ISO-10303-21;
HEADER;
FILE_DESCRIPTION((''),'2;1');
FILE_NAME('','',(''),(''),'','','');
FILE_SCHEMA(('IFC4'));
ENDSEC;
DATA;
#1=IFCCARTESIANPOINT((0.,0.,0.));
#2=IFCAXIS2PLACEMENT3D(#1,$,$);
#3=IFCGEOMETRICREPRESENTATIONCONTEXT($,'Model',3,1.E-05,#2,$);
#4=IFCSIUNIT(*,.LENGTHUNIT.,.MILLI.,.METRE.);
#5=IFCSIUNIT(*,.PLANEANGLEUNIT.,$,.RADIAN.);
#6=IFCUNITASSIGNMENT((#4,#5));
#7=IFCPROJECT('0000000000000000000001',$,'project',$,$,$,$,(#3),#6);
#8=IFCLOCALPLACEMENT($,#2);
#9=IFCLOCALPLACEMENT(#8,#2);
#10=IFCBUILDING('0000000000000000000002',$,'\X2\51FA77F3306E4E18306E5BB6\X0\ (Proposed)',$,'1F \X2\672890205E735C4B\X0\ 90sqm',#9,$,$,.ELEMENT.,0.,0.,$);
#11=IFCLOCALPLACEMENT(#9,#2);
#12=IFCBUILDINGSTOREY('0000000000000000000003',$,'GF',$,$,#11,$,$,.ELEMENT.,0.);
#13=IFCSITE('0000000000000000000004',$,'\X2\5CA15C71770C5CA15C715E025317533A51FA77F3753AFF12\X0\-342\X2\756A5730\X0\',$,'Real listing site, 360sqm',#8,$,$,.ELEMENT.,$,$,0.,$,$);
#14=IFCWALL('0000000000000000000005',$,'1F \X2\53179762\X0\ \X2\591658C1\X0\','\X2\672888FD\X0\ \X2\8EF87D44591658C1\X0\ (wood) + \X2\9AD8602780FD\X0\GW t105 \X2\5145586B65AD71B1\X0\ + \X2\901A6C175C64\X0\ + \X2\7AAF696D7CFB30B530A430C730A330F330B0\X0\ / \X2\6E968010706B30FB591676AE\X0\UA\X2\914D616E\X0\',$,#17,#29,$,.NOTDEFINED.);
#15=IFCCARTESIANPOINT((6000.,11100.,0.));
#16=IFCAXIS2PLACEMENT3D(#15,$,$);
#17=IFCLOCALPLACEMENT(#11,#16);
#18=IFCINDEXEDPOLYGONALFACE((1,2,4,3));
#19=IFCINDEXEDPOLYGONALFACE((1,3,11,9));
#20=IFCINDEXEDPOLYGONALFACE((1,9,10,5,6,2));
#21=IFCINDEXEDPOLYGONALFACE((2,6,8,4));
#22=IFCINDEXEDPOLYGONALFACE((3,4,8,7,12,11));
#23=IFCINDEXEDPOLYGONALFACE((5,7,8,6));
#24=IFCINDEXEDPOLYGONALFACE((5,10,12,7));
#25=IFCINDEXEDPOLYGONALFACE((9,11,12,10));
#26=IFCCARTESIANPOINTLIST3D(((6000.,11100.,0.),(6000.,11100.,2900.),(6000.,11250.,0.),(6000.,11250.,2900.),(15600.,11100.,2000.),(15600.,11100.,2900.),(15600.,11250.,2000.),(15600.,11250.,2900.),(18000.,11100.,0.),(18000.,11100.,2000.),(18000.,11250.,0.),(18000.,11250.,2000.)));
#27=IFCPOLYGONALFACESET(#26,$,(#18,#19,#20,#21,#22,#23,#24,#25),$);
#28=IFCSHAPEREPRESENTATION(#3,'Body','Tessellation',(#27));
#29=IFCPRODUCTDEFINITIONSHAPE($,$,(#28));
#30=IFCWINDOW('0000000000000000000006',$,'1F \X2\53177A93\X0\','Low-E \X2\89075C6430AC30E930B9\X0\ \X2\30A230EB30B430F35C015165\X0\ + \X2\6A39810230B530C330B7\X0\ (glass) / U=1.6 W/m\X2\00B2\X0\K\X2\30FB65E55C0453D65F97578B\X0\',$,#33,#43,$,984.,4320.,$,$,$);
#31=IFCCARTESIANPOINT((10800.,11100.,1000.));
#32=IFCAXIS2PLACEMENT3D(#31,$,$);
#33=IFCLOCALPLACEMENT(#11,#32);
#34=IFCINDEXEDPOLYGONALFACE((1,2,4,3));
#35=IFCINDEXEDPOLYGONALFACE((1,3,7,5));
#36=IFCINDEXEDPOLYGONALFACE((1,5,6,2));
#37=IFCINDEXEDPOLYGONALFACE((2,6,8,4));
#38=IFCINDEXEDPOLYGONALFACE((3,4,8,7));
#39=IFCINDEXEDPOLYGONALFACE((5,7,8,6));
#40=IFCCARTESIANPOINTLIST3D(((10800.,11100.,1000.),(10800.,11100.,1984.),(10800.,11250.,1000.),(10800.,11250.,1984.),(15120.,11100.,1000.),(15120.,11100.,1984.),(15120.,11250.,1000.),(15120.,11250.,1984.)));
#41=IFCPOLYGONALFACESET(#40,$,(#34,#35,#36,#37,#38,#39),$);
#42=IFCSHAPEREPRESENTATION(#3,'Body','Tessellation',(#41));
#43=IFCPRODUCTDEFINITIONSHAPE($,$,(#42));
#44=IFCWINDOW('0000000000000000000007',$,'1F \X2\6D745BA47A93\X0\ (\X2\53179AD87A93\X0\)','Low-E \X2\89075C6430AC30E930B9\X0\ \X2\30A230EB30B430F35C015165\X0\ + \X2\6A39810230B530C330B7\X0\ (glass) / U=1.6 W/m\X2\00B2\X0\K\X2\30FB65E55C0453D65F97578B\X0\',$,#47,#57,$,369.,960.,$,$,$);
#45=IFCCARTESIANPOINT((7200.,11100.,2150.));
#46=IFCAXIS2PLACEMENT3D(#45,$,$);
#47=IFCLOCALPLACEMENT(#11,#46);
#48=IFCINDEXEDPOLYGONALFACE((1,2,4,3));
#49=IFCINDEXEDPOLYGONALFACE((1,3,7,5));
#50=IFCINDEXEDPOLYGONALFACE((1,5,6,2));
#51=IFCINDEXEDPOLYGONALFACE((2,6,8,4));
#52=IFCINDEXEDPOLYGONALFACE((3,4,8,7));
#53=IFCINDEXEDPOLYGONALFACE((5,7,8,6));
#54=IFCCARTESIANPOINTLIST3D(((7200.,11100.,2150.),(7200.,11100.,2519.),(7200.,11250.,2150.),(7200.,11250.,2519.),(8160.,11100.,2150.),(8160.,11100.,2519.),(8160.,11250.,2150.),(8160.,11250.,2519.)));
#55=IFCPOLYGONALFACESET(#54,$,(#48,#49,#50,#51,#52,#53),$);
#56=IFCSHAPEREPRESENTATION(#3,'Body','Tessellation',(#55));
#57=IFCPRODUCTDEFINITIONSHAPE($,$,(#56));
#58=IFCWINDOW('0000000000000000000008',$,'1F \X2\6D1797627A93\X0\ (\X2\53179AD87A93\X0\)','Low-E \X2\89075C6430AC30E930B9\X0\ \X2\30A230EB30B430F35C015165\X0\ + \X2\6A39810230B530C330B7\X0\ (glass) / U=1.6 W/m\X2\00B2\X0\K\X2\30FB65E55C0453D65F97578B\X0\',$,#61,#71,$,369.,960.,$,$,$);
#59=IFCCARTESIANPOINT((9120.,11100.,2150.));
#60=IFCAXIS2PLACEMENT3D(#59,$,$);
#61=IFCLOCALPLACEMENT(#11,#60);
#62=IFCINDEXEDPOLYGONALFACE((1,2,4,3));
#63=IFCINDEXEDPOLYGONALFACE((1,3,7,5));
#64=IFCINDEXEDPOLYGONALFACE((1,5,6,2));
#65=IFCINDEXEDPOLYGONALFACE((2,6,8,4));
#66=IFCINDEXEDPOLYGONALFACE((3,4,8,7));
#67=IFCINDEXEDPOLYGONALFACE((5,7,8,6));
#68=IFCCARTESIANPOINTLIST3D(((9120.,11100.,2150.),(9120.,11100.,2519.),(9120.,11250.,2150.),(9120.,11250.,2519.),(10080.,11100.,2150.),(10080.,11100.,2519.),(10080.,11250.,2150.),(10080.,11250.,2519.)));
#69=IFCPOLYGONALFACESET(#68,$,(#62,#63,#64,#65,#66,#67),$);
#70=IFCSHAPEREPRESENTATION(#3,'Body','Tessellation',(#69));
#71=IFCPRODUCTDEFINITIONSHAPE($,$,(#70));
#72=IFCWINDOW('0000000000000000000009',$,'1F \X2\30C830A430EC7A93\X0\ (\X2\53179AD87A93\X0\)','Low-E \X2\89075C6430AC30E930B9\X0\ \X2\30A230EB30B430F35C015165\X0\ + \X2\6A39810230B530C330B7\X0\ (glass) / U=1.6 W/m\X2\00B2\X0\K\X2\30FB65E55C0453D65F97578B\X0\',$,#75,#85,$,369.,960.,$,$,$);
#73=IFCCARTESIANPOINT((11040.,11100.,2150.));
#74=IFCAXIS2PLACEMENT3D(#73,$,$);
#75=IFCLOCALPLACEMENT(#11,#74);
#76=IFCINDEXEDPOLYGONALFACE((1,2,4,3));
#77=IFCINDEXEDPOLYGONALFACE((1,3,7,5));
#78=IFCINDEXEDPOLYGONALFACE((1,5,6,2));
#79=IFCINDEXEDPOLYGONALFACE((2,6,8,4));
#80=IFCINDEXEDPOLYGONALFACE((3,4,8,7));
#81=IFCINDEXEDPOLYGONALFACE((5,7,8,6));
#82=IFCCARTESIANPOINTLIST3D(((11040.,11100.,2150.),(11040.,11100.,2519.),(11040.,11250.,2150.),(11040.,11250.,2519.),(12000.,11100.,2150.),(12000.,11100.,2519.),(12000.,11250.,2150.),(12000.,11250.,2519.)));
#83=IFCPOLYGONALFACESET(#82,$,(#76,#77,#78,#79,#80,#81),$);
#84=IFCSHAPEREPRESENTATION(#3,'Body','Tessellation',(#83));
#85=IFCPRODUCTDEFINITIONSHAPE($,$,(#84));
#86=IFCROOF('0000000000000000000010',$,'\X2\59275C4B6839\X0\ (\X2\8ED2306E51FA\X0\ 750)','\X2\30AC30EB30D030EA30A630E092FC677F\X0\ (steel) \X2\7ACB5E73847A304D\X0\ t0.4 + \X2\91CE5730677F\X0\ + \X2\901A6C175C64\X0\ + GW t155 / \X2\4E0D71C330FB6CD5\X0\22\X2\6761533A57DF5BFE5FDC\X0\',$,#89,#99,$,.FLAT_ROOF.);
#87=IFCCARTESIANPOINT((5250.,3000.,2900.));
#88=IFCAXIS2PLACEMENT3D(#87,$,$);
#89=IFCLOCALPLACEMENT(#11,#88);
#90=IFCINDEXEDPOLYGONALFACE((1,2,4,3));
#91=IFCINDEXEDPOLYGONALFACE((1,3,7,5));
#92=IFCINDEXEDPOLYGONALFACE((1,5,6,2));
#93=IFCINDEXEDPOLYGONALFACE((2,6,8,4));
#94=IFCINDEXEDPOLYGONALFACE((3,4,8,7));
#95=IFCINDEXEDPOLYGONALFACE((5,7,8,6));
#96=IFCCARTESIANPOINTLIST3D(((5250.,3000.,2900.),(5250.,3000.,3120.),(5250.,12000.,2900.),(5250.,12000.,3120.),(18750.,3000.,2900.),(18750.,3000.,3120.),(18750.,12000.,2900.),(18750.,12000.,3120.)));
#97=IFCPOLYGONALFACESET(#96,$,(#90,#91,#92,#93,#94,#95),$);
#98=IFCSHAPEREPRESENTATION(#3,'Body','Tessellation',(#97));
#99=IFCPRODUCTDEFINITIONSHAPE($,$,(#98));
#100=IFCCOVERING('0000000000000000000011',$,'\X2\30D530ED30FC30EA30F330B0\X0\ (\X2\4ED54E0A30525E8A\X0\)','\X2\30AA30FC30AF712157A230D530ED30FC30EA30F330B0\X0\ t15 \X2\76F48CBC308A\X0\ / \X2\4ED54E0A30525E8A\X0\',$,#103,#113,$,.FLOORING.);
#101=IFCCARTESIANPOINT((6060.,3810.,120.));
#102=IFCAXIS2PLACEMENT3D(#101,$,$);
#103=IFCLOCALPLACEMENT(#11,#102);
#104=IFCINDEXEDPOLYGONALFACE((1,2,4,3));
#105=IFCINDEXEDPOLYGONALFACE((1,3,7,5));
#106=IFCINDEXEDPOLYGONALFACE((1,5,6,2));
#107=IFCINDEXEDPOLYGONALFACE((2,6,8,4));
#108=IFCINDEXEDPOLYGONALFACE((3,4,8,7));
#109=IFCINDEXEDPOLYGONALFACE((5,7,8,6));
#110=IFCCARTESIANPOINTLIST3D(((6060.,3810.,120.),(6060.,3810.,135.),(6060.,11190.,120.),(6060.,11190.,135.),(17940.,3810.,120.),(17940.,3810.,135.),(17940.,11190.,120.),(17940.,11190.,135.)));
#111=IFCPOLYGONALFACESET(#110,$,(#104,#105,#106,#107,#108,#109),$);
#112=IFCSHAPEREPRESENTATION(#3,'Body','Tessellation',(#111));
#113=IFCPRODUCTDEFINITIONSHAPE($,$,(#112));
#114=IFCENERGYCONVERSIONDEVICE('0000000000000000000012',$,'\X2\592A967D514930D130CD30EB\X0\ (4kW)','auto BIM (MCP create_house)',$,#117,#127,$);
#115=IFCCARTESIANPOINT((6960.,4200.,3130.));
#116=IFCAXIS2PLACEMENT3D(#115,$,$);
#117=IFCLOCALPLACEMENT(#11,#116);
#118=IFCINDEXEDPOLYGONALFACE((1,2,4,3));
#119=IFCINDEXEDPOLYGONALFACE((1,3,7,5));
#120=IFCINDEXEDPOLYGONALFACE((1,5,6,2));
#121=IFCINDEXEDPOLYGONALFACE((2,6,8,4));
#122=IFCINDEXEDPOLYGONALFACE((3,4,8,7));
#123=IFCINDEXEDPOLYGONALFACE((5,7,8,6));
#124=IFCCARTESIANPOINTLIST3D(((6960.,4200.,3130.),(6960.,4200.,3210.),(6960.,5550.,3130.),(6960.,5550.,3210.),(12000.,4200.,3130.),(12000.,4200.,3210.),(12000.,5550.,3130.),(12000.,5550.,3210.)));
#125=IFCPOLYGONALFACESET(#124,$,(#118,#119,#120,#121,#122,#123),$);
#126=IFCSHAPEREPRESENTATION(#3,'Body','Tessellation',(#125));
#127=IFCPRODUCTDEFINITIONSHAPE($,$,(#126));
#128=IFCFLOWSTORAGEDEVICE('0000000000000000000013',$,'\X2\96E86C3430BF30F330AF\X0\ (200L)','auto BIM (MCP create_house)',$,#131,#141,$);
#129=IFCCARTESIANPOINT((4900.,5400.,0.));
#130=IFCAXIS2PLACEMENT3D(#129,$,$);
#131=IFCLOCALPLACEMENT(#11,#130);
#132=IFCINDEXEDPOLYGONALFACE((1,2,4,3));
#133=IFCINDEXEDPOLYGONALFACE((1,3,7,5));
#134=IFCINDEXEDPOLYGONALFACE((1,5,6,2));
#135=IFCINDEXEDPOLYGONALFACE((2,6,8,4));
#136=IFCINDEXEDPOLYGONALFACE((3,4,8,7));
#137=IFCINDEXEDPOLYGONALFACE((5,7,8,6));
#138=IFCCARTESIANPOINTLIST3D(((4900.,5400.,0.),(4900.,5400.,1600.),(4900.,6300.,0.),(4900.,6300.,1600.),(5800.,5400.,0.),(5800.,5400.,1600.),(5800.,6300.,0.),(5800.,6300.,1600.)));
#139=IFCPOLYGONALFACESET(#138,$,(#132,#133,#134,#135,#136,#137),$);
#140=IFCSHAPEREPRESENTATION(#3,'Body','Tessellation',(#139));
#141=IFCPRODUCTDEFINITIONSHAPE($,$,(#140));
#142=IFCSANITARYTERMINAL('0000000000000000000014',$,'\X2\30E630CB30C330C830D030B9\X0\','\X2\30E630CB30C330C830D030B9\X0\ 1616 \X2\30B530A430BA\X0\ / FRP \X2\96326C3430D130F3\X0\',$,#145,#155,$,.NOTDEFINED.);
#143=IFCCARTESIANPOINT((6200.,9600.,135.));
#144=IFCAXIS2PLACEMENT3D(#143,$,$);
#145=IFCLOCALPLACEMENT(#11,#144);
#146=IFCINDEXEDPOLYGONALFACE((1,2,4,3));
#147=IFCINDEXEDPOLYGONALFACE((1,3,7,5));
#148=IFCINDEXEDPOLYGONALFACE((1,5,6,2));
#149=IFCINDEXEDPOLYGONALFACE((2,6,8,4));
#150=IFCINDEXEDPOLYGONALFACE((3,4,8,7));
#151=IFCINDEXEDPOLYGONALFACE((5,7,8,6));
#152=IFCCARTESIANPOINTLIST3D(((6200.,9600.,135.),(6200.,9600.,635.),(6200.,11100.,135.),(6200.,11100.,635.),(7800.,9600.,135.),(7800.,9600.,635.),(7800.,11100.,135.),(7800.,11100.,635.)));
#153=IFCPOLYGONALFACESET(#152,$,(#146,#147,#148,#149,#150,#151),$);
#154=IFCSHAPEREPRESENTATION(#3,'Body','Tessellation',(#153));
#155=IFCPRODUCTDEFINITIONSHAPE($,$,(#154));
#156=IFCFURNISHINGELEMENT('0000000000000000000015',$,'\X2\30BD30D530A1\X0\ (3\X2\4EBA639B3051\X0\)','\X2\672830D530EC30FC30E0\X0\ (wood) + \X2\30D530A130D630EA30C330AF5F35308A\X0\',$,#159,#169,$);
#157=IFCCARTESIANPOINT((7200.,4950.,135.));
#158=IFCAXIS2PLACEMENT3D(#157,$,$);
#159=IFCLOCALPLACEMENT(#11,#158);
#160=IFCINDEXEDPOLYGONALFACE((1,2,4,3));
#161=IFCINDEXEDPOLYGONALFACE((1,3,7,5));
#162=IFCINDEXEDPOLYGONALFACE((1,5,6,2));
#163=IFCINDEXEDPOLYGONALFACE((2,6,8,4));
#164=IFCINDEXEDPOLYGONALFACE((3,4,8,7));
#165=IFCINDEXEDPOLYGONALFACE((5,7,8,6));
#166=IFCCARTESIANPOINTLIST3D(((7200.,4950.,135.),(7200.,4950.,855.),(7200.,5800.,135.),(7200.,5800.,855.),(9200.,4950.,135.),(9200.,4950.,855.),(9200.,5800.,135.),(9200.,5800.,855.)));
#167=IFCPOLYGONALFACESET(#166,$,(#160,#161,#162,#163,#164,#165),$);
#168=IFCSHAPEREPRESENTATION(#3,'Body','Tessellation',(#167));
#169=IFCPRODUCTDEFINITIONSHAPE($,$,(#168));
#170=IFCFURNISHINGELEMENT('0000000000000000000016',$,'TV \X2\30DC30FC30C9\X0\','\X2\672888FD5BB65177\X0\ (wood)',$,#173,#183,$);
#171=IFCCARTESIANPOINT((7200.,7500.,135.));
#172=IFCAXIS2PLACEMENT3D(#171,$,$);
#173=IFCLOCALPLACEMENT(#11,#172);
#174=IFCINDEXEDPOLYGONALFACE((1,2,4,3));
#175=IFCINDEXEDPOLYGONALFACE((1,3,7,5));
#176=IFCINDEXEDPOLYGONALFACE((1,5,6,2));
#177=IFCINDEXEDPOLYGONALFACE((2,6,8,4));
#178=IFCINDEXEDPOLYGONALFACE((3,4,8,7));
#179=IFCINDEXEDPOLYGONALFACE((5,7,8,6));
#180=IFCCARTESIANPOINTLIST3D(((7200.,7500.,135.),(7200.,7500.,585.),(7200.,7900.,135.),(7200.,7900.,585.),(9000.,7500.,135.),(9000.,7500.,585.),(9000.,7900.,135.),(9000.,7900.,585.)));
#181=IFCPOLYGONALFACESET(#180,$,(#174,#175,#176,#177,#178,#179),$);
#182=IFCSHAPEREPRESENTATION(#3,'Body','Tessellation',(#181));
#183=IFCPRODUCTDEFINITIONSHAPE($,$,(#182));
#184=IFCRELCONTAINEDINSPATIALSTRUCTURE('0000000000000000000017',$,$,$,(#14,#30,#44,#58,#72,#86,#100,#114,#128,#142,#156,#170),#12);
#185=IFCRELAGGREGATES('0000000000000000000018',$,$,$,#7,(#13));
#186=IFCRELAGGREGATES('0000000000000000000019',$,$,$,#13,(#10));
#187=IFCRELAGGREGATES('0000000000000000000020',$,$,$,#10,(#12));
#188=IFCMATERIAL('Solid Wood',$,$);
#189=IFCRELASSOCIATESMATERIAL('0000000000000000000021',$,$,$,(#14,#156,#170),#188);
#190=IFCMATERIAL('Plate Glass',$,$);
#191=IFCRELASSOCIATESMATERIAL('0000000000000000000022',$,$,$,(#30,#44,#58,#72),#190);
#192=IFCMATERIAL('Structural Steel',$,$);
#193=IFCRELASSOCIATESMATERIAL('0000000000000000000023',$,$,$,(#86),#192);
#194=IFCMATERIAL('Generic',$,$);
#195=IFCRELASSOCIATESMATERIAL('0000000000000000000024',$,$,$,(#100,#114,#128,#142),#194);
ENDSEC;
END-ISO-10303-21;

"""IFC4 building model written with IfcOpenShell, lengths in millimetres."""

from ifc_helpers import new_model, si_unit, frame, frame_2d, origin, place, context, project, spatial, rectangle, extrude, material, element, fill, save


model = new_model("IFC4")

# Units and contexts
model_context = context("Model", 3, precision=1e-05, world=origin())
ifc_project = project(units=[si_unit("LENGTHUNIT", "METRE", prefix="MILLI"), si_unit("PLANEANGLEUNIT", "RADIAN")], contexts=[model_context])

# Site, building, storey
site_placement = place(None, origin())
site = spatial("IfcSite", under=ifc_project, at=site_placement, Name="岡山県岡山市北区出石町２-342番地", ObjectType="Real listing site, 360sqm", CompositionType="ELEMENT", RefElevation=0.0)
building_placement = place(site_placement, origin())
building = spatial("IfcBuilding", under=site, at=building_placement, Name="出石の丘の家 (Proposed)", ObjectType="1F 木造平屋 90sqm", CompositionType="ELEMENT", ElevationOfRefHeight=0.0, ElevationOfTerrain=0.0)
storey_placement = place(building_placement, origin())
storey = spatial("IfcBuildingStorey", under=building, at=storey_placement, Name="GF", CompositionType="ELEMENT", Elevation=0.0)

# Shared definitions
ifc_material_1 = material(Name="Solid Wood")

# Shared definitions
ifc_material_2 = material(Name="Plate Glass")

# Wall, openings, windows
wall_1_placement = place(storey_placement, frame((6000.0, 11100.0, 0.0)))
wall_1 = element("IfcWall", 1, at=wall_1_placement, inside=storey, material=ifc_material_1, Name="1F 北面 外壁", Description="木製 軸組外壁 (wood) + 高性能GW t105 充填断熱 + 通気層 + 窯業系サイディング / 準耐火・外皮UA配慮", PredefinedType="NOTDEFINED", context=model_context, shape_type="SweptSolid", body=[
    extrude(rectangle(XDim=12000.0, YDim=150.0, at=frame_2d((6000.0, 75.0))), frame((6000.0, 11100.0, 0.0)), (0.0, 0.0, 1.0), 2900.0),
])
opening_1_placement = place(storey_placement, frame((10800.0, 11100.0, 1000.0)))
opening_1 = element("IfcOpeningElement", 2, at=opening_1_placement, cuts=wall_1, PredefinedType="NOTDEFINED", context=model_context, shape_type="SweptSolid", body=[
    extrude(rectangle(XDim=4320.0, YDim=150.0, at=frame_2d((2160.0, 75.0))), frame((10800.0, 11100.0, 1000.0)), (0.0, 0.0, 1.0), 984.0),
])
opening_2_placement = place(storey_placement, frame((7200.0, 11100.0, 2150.0)))
opening_2 = element("IfcOpeningElement", 3, at=opening_2_placement, cuts=wall_1, PredefinedType="NOTDEFINED", context=model_context, shape_type="SweptSolid", body=[
    extrude(rectangle(XDim=960.0, YDim=150.0, at=frame_2d((480.0, 75.0))), frame((7200.0, 11100.0, 2150.0)), (0.0, 0.0, 1.0), 369.0),
])
opening_3_placement = place(storey_placement, frame((9120.0, 11100.0, 2150.0)))
opening_3 = element("IfcOpeningElement", 4, at=opening_3_placement, cuts=wall_1, PredefinedType="NOTDEFINED", context=model_context, shape_type="SweptSolid", body=[
    extrude(rectangle(XDim=960.0, YDim=150.0, at=frame_2d((480.0, 75.0))), frame((9120.0, 11100.0, 2150.0)), (0.0, 0.0, 1.0), 369.0),
])
opening_4_placement = place(storey_placement, frame((11040.0, 11100.0, 2150.0)))
opening_4 = element("IfcOpeningElement", 5, at=opening_4_placement, cuts=wall_1, PredefinedType="NOTDEFINED", context=model_context, shape_type="SweptSolid", body=[
    extrude(rectangle(XDim=960.0, YDim=150.0, at=frame_2d((480.0, 75.0))), frame((11040.0, 11100.0, 2150.0)), (0.0, 0.0, 1.0), 369.0),
])
window_1_placement = place(storey_placement, frame((10800.0, 11100.0, 1000.0)))
window_1 = element("IfcWindow", 6, at=window_1_placement, inside=storey, material=ifc_material_2, Name="1F 北窓", Description="Low-E 複層ガラス アルゴン封入 + 樹脂サッシ (glass) / U=1.6 W/m²K・日射取得型", OverallHeight=984.0, OverallWidth=4320.0, context=model_context, shape_type="SweptSolid", body=[
    extrude(rectangle(XDim=4320.0, YDim=150.0, at=frame_2d((2160.0, 75.0))), frame((10800.0, 11100.0, 1000.0)), (0.0, 0.0, 1.0), 984.0),
])
fill(opening_1, window_1)
window_2_placement = place(storey_placement, frame((7200.0, 11100.0, 2150.0)))
window_2 = element("IfcWindow", 7, at=window_2_placement, inside=storey, material=ifc_material_2, Name="1F 浴室窓 (北高窓)", Description="Low-E 複層ガラス アルゴン封入 + 樹脂サッシ (glass) / U=1.6 W/m²K・日射取得型", OverallHeight=369.0, OverallWidth=960.0, context=model_context, shape_type="SweptSolid", body=[
    extrude(rectangle(XDim=960.0, YDim=150.0, at=frame_2d((480.0, 75.0))), frame((7200.0, 11100.0, 2150.0)), (0.0, 0.0, 1.0), 369.0),
])
fill(opening_2, window_2)
window_3_placement = place(storey_placement, frame((9120.0, 11100.0, 2150.0)))
window_3 = element("IfcWindow", 8, at=window_3_placement, inside=storey, material=ifc_material_2, Name="1F 洗面窓 (北高窓)", Description="Low-E 複層ガラス アルゴン封入 + 樹脂サッシ (glass) / U=1.6 W/m²K・日射取得型", OverallHeight=369.0, OverallWidth=960.0, context=model_context, shape_type="SweptSolid", body=[
    extrude(rectangle(XDim=960.0, YDim=150.0, at=frame_2d((480.0, 75.0))), frame((9120.0, 11100.0, 2150.0)), (0.0, 0.0, 1.0), 369.0),
])
fill(opening_3, window_3)
window_4_placement = place(storey_placement, frame((11040.0, 11100.0, 2150.0)))
window_4 = element("IfcWindow", 9, at=window_4_placement, inside=storey, material=ifc_material_2, Name="1F トイレ窓 (北高窓)", Description="Low-E 複層ガラス アルゴン封入 + 樹脂サッシ (glass) / U=1.6 W/m²K・日射取得型", OverallHeight=369.0, OverallWidth=960.0, context=model_context, shape_type="SweptSolid", body=[
    extrude(rectangle(XDim=960.0, YDim=150.0, at=frame_2d((480.0, 75.0))), frame((11040.0, 11100.0, 2150.0)), (0.0, 0.0, 1.0), 369.0),
])
fill(opening_4, window_4)

# Roof
ifc_material_3 = material(Name="Structural Steel")
roof_placement = place(storey_placement, frame((5250.0, 3000.0, 2900.0)))
element("IfcRoof", 10, at=roof_placement, inside=storey, material=ifc_material_3, Name="大屋根 (軒の出 750)", Description="ガルバリウム鋼板 (steel) 立平葺き t0.4 + 野地板 + 通気層 + GW t155 / 不燃・法22条区域対応", PredefinedType="FLAT_ROOF", context=model_context, shape_type="SweptSolid", body=[
    extrude(rectangle(XDim=13500.0, YDim=9000.0, at=frame_2d((6750.0, 4500.0))), frame((5250.0, 3000.0, 2900.0)), (0.0, 0.0, 1.0), 220.0),
])

# Covering
ifc_material_4 = material(Name="Generic")
covering_placement = place(storey_placement, frame((6060.0, 3810.0, 120.0)))
element("IfcCovering", 11, at=covering_placement, inside=storey, material=ifc_material_4, Name="フローリング (仕上げ床)", Description="オーク無垢フローリング t15 直貼り / 仕上げ床", PredefinedType="FLOORING", context=model_context, shape_type="SweptSolid", body=[
    extrude(rectangle(XDim=11880.0, YDim=7380.0, at=frame_2d((5940.0, 3690.0))), frame((6060.0, 3810.0, 120.0)), (0.0, 0.0, 1.0), 15.0),
])

# Energy conversion device
energy_conversion_device_placement = place(storey_placement, frame((6960.0, 4200.0, 3130.0)))
element("IfcEnergyConversionDevice", 12, at=energy_conversion_device_placement, inside=storey, material=ifc_material_4, Name="太陽光パネル (4kW)", Description="auto BIM (MCP create_house)", context=model_context, shape_type="SweptSolid", body=[
    extrude(rectangle(XDim=5040.0, YDim=1350.0, at=frame_2d((2520.0, 675.0))), frame((6960.0, 4200.0, 3130.0)), (0.0, 0.0, 1.0), 80.0),
])

# Flow storage device
flow_storage_device_placement = place(storey_placement, frame((4900.0, 5400.0, 0.0)))
element("IfcFlowStorageDevice", 13, at=flow_storage_device_placement, inside=storey, material=ifc_material_4, Name="雨水タンク (200L)", Description="auto BIM (MCP create_house)", context=model_context, shape_type="SweptSolid", body=[
    extrude(rectangle(XDim=900.0, YDim=900.0, at=frame_2d((450.0, 450.0))), frame((4900.0, 5400.0, 0.0)), (0.0, 0.0, 1.0), 1600.0),
])

# Sanitary terminal
sanitary_terminal_placement = place(storey_placement, frame((6200.0, 9600.0, 135.0)))
element("IfcSanitaryTerminal", 14, at=sanitary_terminal_placement, inside=storey, material=ifc_material_4, Name="ユニットバス", Description="ユニットバス 1616 サイズ / FRP 防水パン", PredefinedType="NOTDEFINED", context=model_context, shape_type="SweptSolid", body=[
    extrude(rectangle(XDim=1600.0, YDim=1500.0, at=frame_2d((800.0, 750.0))), frame((6200.0, 9600.0, 135.0)), (0.0, 0.0, 1.0), 500.0),
])

# Furnishing elements
furnishing_1_placement = place(storey_placement, frame((7200.0, 4950.0, 135.0)))
element("IfcFurnishingElement", 15, at=furnishing_1_placement, inside=storey, material=ifc_material_1, Name="ソファ (3人掛け)", Description="木フレーム (wood) + ファブリック張り", context=model_context, shape_type="SweptSolid", body=[
    extrude(rectangle(XDim=2000.0, YDim=850.0, at=frame_2d((1000.0, 425.0))), frame((7200.0, 4950.0, 135.0)), (0.0, 0.0, 1.0), 720.0),
])
furnishing_2_placement = place(storey_placement, frame((7200.0, 7500.0, 135.0)))
element("IfcFurnishingElement", 16, at=furnishing_2_placement, inside=storey, material=ifc_material_1, Name="TV ボード", Description="木製家具 (wood)", context=model_context, shape_type="SweptSolid", body=[
    extrude(rectangle(XDim=1800.0, YDim=400.0, at=frame_2d((900.0, 200.0))), frame((7200.0, 7500.0, 135.0)), (0.0, 0.0, 1.0), 450.0),
])

save(model, "model.ifc")
